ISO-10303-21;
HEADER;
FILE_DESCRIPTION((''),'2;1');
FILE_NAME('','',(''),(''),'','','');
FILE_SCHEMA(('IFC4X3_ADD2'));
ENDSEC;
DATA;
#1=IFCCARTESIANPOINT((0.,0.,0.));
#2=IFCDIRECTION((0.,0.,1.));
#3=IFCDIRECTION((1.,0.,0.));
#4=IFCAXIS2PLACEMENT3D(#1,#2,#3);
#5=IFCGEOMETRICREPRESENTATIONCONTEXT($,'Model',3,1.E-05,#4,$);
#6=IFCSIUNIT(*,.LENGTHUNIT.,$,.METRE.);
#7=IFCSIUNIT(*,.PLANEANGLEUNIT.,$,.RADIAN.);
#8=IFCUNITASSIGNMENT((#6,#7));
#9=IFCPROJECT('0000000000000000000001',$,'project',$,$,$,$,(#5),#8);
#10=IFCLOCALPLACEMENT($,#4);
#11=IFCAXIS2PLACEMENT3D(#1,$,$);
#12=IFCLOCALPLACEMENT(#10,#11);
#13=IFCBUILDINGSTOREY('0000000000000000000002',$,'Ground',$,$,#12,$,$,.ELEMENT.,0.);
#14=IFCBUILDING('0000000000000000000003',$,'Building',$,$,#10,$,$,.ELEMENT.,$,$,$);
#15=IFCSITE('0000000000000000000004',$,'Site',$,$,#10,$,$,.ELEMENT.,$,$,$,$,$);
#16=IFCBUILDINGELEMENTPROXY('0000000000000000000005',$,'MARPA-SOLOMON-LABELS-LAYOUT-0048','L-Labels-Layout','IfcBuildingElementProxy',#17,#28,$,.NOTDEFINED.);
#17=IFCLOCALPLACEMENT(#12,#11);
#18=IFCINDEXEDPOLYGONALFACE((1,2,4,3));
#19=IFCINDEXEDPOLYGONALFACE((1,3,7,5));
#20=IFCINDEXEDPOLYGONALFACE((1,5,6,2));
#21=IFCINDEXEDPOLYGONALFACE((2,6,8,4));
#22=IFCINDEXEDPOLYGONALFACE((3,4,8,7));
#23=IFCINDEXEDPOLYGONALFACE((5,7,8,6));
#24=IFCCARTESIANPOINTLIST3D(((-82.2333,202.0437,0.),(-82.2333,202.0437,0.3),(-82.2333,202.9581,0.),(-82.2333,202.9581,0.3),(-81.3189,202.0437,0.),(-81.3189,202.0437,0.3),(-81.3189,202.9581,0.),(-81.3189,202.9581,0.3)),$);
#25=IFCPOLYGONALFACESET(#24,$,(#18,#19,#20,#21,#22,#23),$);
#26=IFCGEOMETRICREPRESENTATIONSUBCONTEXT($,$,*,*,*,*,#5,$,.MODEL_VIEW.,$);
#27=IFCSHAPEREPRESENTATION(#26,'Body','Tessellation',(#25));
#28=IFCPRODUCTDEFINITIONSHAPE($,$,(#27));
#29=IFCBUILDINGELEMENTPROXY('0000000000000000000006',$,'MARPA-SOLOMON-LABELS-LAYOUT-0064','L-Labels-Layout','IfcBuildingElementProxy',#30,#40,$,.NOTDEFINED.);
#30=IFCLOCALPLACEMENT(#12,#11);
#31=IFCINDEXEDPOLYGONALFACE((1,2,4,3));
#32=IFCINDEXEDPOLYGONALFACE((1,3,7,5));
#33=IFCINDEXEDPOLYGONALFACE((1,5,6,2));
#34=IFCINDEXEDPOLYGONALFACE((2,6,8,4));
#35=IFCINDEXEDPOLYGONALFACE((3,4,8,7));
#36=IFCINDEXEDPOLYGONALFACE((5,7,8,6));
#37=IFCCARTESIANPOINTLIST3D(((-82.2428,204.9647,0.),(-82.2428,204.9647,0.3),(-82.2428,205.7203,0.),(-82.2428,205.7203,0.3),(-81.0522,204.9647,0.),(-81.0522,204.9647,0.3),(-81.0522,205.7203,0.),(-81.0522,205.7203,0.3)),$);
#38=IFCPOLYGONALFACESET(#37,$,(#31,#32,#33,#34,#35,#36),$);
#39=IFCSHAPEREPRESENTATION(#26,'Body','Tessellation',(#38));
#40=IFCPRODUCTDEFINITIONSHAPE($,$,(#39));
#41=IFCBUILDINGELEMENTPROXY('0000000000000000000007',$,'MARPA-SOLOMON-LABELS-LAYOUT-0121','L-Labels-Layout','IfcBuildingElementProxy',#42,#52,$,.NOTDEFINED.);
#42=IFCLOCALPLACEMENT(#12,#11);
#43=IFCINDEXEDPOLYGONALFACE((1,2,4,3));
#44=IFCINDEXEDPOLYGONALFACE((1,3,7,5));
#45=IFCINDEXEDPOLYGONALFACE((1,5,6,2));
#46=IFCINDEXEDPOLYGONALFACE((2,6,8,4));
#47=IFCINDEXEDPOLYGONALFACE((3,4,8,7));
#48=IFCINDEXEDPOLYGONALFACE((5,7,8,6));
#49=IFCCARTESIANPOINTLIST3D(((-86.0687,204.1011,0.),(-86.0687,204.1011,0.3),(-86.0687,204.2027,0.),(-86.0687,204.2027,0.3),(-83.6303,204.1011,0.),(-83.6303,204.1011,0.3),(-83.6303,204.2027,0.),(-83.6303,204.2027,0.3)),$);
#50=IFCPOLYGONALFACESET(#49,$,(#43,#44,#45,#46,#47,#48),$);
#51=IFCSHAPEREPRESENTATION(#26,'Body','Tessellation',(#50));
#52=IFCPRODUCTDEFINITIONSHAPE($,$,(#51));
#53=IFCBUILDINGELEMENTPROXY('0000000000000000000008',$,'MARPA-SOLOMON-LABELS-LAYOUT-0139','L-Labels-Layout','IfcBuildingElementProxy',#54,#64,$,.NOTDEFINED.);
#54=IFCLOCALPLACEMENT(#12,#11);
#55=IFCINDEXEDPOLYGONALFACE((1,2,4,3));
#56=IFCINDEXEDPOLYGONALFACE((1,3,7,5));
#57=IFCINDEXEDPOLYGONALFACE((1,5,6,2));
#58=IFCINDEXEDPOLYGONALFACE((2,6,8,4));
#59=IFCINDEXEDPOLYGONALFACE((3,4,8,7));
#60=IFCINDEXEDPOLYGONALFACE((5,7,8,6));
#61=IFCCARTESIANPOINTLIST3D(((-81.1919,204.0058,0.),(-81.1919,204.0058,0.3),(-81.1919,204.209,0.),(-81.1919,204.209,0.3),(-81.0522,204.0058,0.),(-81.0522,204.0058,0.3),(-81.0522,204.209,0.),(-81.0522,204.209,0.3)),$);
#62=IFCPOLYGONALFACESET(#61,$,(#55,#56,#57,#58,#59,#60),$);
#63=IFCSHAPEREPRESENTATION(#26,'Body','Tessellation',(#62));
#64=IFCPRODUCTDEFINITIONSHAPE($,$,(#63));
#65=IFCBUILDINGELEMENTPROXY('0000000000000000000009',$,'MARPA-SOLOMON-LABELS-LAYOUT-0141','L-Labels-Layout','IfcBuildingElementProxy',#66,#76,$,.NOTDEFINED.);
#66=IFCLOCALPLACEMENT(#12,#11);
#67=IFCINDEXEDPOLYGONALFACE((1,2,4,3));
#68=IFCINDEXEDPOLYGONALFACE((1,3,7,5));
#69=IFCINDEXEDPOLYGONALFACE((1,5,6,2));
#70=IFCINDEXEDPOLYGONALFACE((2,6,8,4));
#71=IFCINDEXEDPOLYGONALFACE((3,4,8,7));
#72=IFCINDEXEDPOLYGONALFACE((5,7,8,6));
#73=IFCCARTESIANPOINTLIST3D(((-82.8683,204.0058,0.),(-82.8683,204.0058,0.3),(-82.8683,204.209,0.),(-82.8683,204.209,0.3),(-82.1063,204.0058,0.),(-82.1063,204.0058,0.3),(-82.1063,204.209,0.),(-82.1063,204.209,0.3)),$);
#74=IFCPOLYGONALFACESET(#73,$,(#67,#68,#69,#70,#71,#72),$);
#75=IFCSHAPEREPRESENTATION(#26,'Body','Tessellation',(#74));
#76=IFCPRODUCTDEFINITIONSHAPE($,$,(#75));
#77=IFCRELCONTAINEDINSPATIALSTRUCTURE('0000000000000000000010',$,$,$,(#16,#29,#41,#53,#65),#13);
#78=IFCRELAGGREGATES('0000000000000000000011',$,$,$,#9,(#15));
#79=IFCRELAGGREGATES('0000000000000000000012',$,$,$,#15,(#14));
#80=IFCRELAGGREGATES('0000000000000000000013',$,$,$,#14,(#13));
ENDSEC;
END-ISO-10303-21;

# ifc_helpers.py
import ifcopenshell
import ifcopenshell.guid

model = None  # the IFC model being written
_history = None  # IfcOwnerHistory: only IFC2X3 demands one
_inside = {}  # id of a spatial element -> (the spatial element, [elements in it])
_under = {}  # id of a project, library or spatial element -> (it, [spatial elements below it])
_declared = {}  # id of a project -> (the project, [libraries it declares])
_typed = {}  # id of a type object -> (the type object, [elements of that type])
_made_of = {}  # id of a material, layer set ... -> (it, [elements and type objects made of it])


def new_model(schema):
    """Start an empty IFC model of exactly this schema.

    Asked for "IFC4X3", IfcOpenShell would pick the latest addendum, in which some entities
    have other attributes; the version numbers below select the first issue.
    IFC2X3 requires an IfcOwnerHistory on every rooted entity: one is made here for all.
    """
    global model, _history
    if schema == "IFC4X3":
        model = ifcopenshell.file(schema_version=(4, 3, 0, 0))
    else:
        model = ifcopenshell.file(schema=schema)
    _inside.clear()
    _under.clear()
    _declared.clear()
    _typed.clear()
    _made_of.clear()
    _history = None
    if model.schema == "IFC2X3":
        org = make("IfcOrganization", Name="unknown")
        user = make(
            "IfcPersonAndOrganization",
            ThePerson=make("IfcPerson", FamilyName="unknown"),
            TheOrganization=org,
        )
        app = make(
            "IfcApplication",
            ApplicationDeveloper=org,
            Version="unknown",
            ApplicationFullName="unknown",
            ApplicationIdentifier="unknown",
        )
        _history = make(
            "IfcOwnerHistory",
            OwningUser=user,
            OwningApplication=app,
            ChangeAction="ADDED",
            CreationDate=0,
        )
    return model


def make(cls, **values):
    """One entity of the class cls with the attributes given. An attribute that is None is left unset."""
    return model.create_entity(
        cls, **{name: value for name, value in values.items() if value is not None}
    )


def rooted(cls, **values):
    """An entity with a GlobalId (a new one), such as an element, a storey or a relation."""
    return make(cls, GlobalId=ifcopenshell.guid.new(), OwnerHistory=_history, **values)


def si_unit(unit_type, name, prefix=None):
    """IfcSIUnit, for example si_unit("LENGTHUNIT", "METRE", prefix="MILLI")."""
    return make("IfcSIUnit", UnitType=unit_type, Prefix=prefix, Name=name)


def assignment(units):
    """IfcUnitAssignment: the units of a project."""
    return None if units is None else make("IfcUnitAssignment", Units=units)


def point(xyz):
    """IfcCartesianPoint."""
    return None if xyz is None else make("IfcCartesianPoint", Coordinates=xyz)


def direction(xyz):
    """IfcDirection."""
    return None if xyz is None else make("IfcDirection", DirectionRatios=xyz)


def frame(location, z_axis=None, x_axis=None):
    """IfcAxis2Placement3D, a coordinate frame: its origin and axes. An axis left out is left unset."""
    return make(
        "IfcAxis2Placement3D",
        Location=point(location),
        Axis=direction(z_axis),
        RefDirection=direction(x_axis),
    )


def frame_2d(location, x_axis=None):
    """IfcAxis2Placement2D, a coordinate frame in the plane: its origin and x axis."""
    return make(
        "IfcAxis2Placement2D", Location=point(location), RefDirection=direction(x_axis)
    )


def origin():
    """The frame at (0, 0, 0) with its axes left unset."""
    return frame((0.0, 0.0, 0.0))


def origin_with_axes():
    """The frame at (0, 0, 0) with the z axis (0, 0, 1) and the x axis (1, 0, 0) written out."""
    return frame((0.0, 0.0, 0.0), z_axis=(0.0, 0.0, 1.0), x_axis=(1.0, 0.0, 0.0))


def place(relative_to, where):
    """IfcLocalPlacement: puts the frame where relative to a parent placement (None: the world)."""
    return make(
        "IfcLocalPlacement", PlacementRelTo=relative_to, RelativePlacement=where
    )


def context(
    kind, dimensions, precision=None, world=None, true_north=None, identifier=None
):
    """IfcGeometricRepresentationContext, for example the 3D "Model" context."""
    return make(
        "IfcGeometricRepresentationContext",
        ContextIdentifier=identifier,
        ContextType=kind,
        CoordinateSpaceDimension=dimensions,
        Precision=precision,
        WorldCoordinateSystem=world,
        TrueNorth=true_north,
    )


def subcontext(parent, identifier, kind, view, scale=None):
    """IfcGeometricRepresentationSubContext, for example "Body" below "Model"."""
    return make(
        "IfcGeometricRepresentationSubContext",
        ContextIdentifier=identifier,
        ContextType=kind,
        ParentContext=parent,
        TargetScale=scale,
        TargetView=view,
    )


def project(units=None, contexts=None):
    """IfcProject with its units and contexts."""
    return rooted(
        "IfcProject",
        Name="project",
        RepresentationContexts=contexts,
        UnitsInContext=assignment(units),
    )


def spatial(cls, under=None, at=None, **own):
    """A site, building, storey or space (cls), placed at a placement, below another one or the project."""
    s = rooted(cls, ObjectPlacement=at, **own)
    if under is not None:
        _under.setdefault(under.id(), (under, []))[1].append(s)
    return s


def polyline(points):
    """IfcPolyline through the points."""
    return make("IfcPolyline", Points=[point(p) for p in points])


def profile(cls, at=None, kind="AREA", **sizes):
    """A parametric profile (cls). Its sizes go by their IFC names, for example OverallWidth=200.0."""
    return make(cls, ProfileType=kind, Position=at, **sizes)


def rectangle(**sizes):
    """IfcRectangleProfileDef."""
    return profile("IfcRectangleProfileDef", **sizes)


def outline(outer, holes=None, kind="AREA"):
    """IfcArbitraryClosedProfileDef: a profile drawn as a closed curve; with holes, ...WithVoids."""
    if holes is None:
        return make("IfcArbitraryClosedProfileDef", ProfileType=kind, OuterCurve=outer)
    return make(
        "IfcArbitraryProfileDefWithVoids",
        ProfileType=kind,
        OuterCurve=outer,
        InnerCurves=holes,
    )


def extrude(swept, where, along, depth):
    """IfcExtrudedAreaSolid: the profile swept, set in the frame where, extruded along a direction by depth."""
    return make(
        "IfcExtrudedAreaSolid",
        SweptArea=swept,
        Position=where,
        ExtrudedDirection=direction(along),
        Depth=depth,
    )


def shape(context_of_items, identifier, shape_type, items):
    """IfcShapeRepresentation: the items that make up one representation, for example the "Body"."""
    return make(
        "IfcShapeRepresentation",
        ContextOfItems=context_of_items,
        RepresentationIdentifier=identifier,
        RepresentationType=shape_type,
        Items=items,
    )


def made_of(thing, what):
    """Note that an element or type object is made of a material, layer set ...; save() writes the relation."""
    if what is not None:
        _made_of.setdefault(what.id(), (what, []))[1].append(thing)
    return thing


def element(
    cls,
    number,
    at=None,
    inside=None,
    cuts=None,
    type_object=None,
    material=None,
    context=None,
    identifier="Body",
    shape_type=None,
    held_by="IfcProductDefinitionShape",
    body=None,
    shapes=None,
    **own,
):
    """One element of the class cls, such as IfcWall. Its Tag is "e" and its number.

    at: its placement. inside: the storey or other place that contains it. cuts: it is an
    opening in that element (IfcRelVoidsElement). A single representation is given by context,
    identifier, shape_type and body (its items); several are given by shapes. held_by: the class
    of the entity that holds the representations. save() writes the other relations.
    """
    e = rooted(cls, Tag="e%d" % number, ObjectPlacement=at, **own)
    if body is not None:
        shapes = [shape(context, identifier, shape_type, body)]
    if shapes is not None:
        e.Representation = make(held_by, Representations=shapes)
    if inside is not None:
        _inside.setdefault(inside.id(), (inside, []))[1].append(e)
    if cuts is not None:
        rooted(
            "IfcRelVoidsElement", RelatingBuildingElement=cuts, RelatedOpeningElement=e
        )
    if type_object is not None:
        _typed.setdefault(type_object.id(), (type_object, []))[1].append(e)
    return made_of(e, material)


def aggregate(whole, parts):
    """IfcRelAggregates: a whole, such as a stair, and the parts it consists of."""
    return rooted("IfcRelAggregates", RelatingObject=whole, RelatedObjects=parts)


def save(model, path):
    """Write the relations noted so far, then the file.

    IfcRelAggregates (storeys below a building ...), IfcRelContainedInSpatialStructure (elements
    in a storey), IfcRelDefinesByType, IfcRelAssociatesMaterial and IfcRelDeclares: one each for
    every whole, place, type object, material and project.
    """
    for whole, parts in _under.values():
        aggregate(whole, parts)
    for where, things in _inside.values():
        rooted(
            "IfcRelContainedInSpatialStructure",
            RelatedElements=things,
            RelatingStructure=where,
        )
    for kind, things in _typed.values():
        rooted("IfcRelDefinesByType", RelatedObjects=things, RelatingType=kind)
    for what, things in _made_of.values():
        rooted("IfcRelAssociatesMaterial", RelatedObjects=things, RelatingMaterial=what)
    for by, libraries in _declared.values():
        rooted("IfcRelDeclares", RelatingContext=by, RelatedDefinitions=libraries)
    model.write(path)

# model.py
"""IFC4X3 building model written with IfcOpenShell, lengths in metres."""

from ifc_helpers import new_model, si_unit, frame, frame_2d, origin, origin_with_axes, place, context, subcontext, project, spatial, polyline, rectangle, outline, extrude, element, save


model = new_model("IFC4X3")

# Units and contexts
model_context = context("Model", 3, precision=1e-05, world=origin_with_axes())
sub_context = subcontext(model_context, None, None, "MODEL_VIEW")
ifc_project = project(units=[si_unit("LENGTHUNIT", "METRE"), si_unit("PLANEANGLEUNIT", "RADIAN")], contexts=[model_context])

# Site, building, storey
placement = place(None, origin_with_axes())
site = spatial("IfcSite", under=ifc_project, at=placement, Name="Site", CompositionType="ELEMENT")
building = spatial("IfcBuilding", under=site, at=placement, Name="Building", CompositionType="ELEMENT")
storey_placement = place(placement, origin())
storey = spatial("IfcBuildingStorey", under=building, at=storey_placement, Name="Ground", CompositionType="ELEMENT", Elevation=0.0)

# Building element proxies
proxy_1_placement = place(placement, frame((-82.2333, 202.0437, 0.0)))
element("IfcBuildingElementProxy", 1, at=proxy_1_placement, inside=storey, Name="MARPA-SOLOMON-LABELS-LAYOUT-0048", Description="L-Labels-Layout", ObjectType="IfcBuildingElementProxy", PredefinedType="NOTDEFINED", context=sub_context, shape_type="SweptSolid", body=[
    extrude(outline(polyline([(0.0, 0.0), (0.0, 0.9144), (0.9144, 0.9144), (0.9144, 0.0), (0.0, 0.0)])), origin(), (0.0, 0.0, 1.0), 0.3),
])
proxy_2_placement = place(placement, frame((-82.2428, 204.9647, 0.0)))
element("IfcBuildingElementProxy", 2, at=proxy_2_placement, inside=storey, Name="MARPA-SOLOMON-LABELS-LAYOUT-0064", Description="L-Labels-Layout", ObjectType="IfcBuildingElementProxy", PredefinedType="NOTDEFINED", context=sub_context, shape_type="SweptSolid", body=[
    extrude(rectangle(XDim=1.1906, YDim=0.7556, at=frame_2d((0.5953, 0.3778))), origin(), (0.0, 0.0, 1.0), 0.3),
])
proxy_3_placement = place(placement, frame((-86.0687, 204.1011, 0.0)))
element("IfcBuildingElementProxy", 3, at=proxy_3_placement, inside=storey, Name="MARPA-SOLOMON-LABELS-LAYOUT-0121", Description="L-Labels-Layout", ObjectType="IfcBuildingElementProxy", PredefinedType="NOTDEFINED", context=sub_context, shape_type="SweptSolid", body=[
    extrude(outline(polyline([(0.0, 0.0), (0.0, 0.1016), (2.4384, 0.1016), (2.4384, 0.0), (0.0, 0.0)])), origin(), (0.0, 0.0, 1.0), 0.3),
])
proxy_4_placement = place(placement, frame((-81.1919, 204.0058, 0.0)))
element("IfcBuildingElementProxy", 4, at=proxy_4_placement, inside=storey, Name="MARPA-SOLOMON-LABELS-LAYOUT-0139", Description="L-Labels-Layout", ObjectType="IfcBuildingElementProxy", PredefinedType="NOTDEFINED", context=sub_context, shape_type="SweptSolid", body=[
    extrude(rectangle(XDim=0.1397, YDim=0.2032, at=frame_2d((0.0699, 0.1016))), origin(), (0.0, 0.0, 1.0), 0.3),
])
proxy_5_placement = place(placement, frame((-82.8683, 204.0058, 0.0)))
element("IfcBuildingElementProxy", 5, at=proxy_5_placement, inside=storey, Name="MARPA-SOLOMON-LABELS-LAYOUT-0141", Description="L-Labels-Layout", ObjectType="IfcBuildingElementProxy", PredefinedType="NOTDEFINED", context=sub_context, shape_type="SweptSolid", body=[
    extrude(outline(polyline([(0.0, 0.0), (0.0, 0.2032), (0.762, 0.2032), (0.762, 0.0), (0.0, 0.0)])), origin(), (0.0, 0.0, 1.0), 0.3),
])

save(model, "model.ifc")
